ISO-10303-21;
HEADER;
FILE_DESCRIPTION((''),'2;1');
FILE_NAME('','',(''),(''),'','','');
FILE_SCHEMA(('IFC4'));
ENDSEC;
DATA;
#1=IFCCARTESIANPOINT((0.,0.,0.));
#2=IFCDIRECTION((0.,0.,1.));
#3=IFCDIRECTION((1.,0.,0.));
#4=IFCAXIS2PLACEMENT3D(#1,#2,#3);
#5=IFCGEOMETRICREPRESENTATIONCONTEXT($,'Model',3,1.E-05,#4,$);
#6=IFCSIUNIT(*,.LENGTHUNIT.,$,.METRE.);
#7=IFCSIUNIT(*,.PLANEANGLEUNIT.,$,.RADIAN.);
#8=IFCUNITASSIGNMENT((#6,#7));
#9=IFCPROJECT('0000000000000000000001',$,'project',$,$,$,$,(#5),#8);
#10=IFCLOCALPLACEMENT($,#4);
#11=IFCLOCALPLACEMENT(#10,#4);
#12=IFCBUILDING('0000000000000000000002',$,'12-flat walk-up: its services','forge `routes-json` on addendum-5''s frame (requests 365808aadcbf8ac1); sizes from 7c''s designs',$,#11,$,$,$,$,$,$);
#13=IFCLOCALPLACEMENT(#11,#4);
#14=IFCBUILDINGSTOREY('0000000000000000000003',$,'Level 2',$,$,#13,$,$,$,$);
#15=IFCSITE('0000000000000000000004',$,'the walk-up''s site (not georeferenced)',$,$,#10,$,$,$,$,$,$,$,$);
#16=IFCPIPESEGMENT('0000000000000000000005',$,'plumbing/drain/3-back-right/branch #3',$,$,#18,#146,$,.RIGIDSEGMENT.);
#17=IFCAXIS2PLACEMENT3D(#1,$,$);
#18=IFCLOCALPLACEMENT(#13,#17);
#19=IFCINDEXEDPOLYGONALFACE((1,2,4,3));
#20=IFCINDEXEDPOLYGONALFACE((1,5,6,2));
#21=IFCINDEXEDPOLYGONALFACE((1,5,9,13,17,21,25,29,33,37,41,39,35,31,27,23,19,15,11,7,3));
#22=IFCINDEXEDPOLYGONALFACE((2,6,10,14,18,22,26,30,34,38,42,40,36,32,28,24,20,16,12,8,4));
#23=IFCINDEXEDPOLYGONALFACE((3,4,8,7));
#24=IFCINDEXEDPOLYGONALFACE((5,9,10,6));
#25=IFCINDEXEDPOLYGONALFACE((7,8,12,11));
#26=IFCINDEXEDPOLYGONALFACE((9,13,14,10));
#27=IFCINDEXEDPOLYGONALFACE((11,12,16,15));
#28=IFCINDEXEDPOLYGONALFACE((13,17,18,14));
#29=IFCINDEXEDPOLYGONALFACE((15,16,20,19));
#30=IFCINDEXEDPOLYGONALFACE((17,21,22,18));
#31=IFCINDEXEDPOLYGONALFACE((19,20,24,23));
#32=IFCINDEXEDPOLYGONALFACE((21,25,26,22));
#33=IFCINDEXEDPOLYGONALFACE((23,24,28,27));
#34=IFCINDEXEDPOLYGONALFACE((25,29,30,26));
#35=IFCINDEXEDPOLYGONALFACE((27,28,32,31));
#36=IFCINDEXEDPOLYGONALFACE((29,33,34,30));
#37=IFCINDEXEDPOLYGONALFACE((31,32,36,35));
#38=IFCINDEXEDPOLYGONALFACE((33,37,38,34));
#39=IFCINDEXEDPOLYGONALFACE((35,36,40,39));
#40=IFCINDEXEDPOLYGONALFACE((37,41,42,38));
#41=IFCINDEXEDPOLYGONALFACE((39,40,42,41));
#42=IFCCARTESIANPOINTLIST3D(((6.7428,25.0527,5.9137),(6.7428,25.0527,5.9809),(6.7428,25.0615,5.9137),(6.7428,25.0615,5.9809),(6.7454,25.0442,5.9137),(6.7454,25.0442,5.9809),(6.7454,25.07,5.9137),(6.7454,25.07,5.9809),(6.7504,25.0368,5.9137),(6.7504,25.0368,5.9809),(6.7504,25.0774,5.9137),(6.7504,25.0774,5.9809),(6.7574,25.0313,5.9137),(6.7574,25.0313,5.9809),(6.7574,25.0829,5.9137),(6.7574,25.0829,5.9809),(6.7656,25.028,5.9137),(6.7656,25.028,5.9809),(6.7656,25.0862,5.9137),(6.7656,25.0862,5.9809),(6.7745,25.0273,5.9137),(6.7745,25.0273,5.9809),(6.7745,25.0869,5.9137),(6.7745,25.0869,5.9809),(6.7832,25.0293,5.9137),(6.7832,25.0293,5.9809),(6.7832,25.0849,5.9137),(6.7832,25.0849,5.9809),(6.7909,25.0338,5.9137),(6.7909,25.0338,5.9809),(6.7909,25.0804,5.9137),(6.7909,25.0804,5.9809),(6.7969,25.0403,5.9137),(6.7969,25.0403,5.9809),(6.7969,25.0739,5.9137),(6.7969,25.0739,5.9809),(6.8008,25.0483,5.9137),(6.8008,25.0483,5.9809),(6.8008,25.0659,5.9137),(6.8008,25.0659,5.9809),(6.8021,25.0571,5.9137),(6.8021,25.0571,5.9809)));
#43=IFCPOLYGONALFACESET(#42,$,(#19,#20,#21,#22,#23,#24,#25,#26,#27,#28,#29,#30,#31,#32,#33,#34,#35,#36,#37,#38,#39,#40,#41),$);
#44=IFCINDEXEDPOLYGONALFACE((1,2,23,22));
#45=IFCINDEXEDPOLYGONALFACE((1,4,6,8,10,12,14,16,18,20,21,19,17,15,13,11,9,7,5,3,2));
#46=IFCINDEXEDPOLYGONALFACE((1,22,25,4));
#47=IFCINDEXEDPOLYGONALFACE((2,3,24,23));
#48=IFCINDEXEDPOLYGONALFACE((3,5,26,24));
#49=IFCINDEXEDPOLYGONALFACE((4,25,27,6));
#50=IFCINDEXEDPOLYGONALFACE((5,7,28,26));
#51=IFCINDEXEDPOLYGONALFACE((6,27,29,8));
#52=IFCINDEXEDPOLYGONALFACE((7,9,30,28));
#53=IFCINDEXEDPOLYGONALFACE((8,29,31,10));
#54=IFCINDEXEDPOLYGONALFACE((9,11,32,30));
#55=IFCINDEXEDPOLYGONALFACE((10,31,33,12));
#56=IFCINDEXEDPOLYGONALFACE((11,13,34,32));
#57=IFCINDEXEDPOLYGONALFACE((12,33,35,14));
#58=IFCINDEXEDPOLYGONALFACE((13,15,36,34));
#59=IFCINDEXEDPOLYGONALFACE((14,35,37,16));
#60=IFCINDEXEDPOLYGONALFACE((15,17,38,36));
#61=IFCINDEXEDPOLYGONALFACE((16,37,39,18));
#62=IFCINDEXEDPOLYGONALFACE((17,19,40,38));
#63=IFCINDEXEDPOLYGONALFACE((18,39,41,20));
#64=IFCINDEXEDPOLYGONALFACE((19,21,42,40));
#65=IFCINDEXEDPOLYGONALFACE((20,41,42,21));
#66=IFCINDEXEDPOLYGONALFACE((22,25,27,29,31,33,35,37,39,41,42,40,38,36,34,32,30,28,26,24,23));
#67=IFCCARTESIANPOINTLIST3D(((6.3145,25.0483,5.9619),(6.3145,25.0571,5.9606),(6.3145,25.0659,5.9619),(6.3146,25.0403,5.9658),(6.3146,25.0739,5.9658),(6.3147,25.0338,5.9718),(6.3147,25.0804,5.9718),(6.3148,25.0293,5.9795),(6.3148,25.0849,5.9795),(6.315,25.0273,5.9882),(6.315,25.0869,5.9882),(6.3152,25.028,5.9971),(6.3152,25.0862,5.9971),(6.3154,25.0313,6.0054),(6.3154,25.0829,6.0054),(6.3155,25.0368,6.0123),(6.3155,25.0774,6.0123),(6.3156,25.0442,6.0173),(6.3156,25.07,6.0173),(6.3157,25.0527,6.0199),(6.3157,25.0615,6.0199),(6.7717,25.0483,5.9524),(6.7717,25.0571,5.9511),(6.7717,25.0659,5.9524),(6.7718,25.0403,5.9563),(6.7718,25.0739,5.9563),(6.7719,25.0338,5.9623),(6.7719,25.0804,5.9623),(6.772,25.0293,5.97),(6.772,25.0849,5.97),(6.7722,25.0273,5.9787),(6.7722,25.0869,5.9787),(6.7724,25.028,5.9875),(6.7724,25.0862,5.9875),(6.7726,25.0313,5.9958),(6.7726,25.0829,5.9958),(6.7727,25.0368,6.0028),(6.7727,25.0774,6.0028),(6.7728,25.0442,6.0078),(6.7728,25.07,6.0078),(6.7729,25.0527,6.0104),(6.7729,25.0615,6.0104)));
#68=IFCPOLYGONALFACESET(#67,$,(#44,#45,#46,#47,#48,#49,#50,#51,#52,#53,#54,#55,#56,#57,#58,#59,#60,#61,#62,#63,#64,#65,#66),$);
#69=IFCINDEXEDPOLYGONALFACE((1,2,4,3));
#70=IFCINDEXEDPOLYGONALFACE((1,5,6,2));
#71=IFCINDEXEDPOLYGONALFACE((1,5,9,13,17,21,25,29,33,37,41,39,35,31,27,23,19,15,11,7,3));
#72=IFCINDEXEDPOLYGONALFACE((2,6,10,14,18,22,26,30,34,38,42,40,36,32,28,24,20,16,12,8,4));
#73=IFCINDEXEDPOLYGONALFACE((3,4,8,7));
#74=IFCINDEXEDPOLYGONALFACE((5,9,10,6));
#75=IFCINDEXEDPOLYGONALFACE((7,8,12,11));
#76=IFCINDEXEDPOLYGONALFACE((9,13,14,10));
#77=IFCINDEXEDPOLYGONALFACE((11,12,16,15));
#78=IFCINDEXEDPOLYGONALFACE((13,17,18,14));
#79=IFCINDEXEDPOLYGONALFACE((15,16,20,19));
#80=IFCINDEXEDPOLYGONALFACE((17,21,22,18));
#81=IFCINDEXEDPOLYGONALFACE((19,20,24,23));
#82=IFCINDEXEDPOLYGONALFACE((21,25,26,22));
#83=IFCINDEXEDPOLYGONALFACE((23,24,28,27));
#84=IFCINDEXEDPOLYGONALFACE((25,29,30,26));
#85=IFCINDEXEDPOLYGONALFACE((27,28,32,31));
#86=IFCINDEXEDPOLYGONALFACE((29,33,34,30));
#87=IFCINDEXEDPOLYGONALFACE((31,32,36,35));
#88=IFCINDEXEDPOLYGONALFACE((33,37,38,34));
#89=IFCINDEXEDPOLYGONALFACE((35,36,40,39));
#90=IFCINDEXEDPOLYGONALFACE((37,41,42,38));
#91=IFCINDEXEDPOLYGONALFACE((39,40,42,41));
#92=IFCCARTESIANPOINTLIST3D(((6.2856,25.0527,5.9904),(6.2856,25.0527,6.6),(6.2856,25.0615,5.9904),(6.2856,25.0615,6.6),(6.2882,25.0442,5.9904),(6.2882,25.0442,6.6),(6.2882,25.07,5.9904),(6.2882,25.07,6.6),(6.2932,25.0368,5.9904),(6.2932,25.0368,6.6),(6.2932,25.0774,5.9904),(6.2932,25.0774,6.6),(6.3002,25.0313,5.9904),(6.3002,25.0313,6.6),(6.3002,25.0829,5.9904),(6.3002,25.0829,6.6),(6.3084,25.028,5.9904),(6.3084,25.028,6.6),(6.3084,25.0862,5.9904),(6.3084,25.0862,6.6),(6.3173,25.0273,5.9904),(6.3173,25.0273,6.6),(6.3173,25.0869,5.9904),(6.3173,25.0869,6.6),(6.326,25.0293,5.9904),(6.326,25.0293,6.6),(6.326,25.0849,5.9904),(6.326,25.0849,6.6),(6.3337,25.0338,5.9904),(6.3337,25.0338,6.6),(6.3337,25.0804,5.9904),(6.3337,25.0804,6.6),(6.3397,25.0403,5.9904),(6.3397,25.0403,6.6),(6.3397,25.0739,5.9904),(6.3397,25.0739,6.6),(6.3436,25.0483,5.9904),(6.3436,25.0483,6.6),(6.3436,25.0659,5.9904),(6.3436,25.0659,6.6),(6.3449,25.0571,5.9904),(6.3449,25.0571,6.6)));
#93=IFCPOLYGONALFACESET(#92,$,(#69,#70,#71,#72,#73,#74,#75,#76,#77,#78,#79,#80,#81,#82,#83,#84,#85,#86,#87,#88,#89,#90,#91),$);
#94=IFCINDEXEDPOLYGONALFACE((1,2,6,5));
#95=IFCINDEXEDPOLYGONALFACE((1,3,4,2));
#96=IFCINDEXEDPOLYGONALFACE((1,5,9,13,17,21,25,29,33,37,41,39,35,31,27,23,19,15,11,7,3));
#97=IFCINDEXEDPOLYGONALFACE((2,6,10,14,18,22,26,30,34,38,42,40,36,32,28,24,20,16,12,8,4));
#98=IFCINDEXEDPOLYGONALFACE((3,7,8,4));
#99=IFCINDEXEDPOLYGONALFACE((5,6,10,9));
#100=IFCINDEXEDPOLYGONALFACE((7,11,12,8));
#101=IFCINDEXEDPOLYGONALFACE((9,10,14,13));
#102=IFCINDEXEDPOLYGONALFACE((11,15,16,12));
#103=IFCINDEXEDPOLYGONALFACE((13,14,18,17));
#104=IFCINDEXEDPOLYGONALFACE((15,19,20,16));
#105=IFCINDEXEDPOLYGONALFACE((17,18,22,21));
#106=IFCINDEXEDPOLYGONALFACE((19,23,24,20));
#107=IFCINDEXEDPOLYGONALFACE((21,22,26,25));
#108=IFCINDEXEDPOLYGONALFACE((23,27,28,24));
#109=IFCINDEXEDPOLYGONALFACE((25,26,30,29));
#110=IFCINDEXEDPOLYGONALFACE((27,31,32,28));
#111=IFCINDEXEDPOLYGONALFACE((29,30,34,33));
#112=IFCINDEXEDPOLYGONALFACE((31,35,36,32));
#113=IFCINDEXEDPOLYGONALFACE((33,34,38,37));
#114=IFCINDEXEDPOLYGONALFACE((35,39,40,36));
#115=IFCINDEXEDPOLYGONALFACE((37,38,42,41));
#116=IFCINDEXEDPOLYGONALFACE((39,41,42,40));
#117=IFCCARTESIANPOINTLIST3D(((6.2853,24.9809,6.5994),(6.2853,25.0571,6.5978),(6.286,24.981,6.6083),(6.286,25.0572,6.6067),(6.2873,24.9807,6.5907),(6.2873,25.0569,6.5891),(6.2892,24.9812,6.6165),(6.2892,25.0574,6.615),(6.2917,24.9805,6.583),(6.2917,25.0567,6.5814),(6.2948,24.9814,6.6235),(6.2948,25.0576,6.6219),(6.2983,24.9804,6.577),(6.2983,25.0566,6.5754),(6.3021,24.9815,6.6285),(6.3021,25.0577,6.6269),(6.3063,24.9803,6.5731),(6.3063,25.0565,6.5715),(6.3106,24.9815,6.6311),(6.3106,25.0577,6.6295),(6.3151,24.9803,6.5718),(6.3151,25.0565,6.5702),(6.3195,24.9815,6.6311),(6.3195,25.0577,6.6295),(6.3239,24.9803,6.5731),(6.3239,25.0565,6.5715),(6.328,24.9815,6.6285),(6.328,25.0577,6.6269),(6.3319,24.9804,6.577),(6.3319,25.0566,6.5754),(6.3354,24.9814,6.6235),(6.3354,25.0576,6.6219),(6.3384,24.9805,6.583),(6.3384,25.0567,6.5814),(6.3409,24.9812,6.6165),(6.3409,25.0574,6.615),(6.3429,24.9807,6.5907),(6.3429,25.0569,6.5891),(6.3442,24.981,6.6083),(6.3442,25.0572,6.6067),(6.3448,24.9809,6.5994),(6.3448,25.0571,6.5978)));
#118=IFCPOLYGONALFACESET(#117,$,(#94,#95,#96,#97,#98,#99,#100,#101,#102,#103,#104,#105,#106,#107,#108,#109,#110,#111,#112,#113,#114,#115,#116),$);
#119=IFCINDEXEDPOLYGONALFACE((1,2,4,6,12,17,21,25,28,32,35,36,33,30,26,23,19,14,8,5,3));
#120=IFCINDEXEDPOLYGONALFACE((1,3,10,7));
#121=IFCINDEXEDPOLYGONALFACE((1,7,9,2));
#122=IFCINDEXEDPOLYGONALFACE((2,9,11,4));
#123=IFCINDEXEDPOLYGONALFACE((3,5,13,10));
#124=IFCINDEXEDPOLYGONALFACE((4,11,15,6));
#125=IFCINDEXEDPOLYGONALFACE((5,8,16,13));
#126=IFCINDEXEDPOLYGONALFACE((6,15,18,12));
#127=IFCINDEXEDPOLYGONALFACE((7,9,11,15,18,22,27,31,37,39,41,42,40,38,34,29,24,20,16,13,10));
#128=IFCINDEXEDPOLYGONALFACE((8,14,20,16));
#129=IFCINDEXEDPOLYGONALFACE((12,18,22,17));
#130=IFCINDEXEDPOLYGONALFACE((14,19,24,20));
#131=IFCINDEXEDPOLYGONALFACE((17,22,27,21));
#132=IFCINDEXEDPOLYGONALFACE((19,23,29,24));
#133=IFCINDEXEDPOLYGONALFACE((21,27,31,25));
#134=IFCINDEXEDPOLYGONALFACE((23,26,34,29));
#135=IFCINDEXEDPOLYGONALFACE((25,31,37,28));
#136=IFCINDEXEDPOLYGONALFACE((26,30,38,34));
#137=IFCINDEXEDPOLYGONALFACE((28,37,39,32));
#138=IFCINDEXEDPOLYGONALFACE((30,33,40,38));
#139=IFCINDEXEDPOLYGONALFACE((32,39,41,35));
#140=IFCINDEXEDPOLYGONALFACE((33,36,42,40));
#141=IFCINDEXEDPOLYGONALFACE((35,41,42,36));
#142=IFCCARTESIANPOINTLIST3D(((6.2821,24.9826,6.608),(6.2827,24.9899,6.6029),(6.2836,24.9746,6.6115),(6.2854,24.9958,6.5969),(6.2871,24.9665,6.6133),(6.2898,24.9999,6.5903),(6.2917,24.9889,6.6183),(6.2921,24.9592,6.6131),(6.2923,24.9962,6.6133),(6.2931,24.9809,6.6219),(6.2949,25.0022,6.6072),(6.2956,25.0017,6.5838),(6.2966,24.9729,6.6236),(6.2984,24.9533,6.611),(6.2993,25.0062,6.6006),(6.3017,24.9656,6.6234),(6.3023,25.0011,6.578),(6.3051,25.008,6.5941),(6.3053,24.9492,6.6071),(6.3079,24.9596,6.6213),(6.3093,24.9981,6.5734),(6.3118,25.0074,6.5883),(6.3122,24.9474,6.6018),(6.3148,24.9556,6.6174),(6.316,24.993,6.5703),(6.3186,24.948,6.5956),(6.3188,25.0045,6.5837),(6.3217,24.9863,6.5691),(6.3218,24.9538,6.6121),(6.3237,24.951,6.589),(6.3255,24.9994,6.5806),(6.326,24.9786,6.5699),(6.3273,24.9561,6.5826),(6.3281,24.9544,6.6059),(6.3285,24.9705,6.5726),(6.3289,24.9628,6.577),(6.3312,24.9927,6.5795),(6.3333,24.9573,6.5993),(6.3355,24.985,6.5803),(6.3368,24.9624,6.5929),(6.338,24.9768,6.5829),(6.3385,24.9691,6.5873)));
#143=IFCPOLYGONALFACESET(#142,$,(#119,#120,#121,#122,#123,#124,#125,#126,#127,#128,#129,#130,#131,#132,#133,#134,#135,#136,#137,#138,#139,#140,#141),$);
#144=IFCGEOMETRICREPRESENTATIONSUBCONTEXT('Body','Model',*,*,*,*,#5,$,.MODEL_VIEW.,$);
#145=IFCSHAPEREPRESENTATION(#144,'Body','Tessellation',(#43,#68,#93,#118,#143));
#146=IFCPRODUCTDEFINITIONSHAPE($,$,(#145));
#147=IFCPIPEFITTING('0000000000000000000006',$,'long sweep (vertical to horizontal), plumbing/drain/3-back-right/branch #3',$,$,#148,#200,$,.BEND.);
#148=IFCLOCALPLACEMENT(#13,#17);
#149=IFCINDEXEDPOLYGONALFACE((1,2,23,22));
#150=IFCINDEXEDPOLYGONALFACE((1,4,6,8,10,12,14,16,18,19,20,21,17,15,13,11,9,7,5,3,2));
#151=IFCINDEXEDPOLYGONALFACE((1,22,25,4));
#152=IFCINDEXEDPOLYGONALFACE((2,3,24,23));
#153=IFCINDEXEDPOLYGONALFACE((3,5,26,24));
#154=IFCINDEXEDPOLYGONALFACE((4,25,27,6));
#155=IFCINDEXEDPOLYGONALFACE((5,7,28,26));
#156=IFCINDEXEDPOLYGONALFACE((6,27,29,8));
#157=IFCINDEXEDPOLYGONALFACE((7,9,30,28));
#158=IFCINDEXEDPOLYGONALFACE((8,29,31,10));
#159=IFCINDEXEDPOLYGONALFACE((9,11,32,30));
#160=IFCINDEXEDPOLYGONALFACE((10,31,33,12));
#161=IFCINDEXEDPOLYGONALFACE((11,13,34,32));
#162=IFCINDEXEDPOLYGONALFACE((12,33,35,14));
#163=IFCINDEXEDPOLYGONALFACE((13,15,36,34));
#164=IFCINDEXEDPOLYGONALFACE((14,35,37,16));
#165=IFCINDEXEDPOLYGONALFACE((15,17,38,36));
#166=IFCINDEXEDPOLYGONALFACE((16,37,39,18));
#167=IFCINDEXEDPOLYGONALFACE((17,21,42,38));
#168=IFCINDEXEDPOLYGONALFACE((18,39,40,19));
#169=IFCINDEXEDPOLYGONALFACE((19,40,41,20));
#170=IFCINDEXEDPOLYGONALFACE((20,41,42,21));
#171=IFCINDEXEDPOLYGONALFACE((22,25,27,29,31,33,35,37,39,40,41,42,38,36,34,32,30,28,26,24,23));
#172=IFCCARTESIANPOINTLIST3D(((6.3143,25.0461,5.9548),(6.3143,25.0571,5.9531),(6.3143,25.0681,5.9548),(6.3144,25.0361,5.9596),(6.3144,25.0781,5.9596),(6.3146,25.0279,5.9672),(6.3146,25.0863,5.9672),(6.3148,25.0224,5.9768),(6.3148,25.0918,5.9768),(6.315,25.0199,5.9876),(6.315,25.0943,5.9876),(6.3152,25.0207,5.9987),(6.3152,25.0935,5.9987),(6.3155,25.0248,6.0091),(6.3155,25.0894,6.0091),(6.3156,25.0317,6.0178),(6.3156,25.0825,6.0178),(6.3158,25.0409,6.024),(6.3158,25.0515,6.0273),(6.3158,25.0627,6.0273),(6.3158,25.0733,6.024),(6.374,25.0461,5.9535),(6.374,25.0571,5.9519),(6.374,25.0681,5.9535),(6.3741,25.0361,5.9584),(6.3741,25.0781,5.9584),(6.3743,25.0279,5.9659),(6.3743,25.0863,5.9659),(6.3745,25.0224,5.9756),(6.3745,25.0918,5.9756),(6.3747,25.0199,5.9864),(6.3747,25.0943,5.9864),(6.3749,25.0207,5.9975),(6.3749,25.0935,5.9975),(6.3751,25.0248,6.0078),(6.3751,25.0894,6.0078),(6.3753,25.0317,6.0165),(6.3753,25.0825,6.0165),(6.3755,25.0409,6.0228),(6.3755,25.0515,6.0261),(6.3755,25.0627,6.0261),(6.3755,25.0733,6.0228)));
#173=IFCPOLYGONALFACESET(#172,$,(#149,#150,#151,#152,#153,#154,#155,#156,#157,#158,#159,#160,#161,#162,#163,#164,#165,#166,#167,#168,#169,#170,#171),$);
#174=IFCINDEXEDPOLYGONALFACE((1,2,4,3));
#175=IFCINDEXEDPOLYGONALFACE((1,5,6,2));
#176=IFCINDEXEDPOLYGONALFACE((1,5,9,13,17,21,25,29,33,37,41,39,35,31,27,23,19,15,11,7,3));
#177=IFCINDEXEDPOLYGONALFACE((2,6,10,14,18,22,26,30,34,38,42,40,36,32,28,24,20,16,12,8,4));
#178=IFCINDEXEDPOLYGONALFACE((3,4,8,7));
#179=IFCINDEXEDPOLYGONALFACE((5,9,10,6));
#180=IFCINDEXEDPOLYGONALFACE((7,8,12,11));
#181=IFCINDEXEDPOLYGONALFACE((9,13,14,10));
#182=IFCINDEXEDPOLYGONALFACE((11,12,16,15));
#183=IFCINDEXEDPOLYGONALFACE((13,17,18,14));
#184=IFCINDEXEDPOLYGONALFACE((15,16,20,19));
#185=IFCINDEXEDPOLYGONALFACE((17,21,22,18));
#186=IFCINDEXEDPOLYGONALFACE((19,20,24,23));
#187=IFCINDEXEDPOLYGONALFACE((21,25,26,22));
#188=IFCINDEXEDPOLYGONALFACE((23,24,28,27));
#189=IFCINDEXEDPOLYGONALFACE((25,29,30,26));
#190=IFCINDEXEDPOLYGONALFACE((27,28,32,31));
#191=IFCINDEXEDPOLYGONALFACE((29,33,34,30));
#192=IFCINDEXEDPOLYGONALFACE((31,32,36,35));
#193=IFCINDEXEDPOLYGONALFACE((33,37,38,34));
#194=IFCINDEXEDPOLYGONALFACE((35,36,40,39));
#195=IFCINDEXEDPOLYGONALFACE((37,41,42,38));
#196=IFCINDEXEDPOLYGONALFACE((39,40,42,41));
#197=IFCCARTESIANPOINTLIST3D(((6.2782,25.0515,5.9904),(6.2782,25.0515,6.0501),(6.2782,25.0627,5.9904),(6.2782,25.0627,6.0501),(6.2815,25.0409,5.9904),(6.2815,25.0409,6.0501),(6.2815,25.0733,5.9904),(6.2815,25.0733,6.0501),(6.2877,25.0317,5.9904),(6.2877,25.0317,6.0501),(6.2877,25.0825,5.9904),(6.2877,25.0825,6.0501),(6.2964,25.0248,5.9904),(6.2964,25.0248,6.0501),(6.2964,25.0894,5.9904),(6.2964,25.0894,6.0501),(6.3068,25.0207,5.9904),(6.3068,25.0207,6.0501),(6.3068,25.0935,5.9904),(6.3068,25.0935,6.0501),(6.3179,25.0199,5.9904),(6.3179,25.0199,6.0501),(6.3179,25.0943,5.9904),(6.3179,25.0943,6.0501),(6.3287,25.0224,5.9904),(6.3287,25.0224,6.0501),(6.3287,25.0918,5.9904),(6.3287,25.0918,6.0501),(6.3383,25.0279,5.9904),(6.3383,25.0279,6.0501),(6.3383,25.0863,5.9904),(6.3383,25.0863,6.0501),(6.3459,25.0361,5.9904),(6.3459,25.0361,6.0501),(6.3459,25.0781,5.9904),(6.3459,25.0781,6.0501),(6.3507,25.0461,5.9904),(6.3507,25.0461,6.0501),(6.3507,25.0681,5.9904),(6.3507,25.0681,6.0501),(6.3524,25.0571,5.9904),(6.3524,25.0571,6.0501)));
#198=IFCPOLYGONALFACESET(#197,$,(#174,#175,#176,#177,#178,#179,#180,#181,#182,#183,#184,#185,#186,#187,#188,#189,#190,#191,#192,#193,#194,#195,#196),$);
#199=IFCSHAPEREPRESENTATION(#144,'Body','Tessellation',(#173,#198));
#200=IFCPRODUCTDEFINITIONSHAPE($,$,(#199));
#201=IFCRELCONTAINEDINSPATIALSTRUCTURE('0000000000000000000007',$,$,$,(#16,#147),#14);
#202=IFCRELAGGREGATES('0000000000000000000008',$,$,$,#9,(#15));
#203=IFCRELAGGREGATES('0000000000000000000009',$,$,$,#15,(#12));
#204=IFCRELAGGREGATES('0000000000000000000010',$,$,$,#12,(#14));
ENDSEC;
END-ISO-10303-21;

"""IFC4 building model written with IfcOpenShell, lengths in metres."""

from ifc_helpers import new_model, entity, si_unit, frame, origin_with_axes, place, context, subcontext, project, spatial, element, save


model = new_model("IFC4")

# Units and contexts
model_context = context("Model", 3, precision=1e-05, world=origin_with_axes())
body_context = subcontext(model_context, "Body", "Model", "MODEL_VIEW")
ifc_project = project(units=[si_unit("LENGTHUNIT", "METRE"), si_unit("PLANEANGLEUNIT", "RADIAN")], contexts=[model_context])

# Site, building, storey
site_placement = place(None, origin_with_axes())
site = spatial("IfcSite", under=ifc_project, at=site_placement, Name="the walk-up's site (not georeferenced)")
building_placement = place(site_placement, origin_with_axes())
building = spatial("IfcBuilding", under=site, at=building_placement, Name="12-flat walk-up: its services", Description="forge `routes-json` on addendum-5's frame (requests 365808aadcbf8ac1); sizes from 7c's designs")
storey_placement = place(building_placement, origin_with_axes())
storey = spatial("IfcBuildingStorey", under=building, at=storey_placement, Name="Level 2")

# Pipe segment
pipe_segment_1_placement = place(storey_placement, frame((6.7723, 25.0571, 5.9137), z_axis=(0.0, 0.0, 1.0), x_axis=(1.0, 0.0, 0.0)))
element("IfcPipeSegment", 1, at=pipe_segment_1_placement, inside=storey, Name="plumbing/drain/3-back-right/branch #3", PredefinedType="RIGIDSEGMENT", context=body_context, shape_type="AdvancedSweptSolid", body=[
    entity("IfcSweptDiskSolid", entity("IfcPolyline", [entity("IfcCartesianPoint", [0.0, 0.0, 0.0]), entity("IfcCartesianPoint", [0.0, 0.0, 0.0672])]), 0.0298),
    entity("IfcSweptDiskSolid", entity("IfcPolyline", [entity("IfcCartesianPoint", [0.0, 0.0, 0.0672]), entity("IfcCartesianPoint", [-0.4572, 0.0, 0.0767])]), 0.0298),
    entity("IfcSweptDiskSolid", entity("IfcPolyline", [entity("IfcCartesianPoint", [-0.4572, 0.0, 0.0767]), entity("IfcCartesianPoint", [-0.4572, 0.0, 0.6863])]), 0.0298),
    entity("IfcSweptDiskSolid", entity("IfcPolyline", [entity("IfcCartesianPoint", [-0.4572, 0.0, 0.6863]), entity("IfcCartesianPoint", [-0.4572, -0.0762, 0.6879])]), 0.0298),
    entity("IfcSweptDiskSolid", entity("IfcPolyline", [entity("IfcCartesianPoint", [-0.4572, -0.0762, 0.6879]), entity("IfcCartesianPoint", [-0.4667, -0.0826, 0.6776])]), 0.0298),
])

# Pipe fitting
pipe_fitting_1_placement = place(storey_placement, frame((6.3748, 25.0571, 5.9892), z_axis=(0.0, 0.0, 1.0), x_axis=(1.0, 0.0, 0.0)))
element("IfcPipeFitting", 2, at=pipe_fitting_1_placement, inside=storey, Name="long sweep (vertical to horizontal), plumbing/drain/3-back-right/branch #3", PredefinedType="BEND", context=body_context, shape_type="AdvancedSweptSolid", body=[
    entity("IfcSweptDiskSolid", entity("IfcPolyline", [entity("IfcCartesianPoint", [0.0, 0.0, 0.0]), entity("IfcCartesianPoint", [-0.0597, 0.0, 0.0012])]), 0.0373),
    entity("IfcSweptDiskSolid", entity("IfcPolyline", [entity("IfcCartesianPoint", [-0.0597, 0.0, 0.0012]), entity("IfcCartesianPoint", [-0.0597, 0.0, 0.0609])]), 0.0373),
])

save(model, "model.ifc")
